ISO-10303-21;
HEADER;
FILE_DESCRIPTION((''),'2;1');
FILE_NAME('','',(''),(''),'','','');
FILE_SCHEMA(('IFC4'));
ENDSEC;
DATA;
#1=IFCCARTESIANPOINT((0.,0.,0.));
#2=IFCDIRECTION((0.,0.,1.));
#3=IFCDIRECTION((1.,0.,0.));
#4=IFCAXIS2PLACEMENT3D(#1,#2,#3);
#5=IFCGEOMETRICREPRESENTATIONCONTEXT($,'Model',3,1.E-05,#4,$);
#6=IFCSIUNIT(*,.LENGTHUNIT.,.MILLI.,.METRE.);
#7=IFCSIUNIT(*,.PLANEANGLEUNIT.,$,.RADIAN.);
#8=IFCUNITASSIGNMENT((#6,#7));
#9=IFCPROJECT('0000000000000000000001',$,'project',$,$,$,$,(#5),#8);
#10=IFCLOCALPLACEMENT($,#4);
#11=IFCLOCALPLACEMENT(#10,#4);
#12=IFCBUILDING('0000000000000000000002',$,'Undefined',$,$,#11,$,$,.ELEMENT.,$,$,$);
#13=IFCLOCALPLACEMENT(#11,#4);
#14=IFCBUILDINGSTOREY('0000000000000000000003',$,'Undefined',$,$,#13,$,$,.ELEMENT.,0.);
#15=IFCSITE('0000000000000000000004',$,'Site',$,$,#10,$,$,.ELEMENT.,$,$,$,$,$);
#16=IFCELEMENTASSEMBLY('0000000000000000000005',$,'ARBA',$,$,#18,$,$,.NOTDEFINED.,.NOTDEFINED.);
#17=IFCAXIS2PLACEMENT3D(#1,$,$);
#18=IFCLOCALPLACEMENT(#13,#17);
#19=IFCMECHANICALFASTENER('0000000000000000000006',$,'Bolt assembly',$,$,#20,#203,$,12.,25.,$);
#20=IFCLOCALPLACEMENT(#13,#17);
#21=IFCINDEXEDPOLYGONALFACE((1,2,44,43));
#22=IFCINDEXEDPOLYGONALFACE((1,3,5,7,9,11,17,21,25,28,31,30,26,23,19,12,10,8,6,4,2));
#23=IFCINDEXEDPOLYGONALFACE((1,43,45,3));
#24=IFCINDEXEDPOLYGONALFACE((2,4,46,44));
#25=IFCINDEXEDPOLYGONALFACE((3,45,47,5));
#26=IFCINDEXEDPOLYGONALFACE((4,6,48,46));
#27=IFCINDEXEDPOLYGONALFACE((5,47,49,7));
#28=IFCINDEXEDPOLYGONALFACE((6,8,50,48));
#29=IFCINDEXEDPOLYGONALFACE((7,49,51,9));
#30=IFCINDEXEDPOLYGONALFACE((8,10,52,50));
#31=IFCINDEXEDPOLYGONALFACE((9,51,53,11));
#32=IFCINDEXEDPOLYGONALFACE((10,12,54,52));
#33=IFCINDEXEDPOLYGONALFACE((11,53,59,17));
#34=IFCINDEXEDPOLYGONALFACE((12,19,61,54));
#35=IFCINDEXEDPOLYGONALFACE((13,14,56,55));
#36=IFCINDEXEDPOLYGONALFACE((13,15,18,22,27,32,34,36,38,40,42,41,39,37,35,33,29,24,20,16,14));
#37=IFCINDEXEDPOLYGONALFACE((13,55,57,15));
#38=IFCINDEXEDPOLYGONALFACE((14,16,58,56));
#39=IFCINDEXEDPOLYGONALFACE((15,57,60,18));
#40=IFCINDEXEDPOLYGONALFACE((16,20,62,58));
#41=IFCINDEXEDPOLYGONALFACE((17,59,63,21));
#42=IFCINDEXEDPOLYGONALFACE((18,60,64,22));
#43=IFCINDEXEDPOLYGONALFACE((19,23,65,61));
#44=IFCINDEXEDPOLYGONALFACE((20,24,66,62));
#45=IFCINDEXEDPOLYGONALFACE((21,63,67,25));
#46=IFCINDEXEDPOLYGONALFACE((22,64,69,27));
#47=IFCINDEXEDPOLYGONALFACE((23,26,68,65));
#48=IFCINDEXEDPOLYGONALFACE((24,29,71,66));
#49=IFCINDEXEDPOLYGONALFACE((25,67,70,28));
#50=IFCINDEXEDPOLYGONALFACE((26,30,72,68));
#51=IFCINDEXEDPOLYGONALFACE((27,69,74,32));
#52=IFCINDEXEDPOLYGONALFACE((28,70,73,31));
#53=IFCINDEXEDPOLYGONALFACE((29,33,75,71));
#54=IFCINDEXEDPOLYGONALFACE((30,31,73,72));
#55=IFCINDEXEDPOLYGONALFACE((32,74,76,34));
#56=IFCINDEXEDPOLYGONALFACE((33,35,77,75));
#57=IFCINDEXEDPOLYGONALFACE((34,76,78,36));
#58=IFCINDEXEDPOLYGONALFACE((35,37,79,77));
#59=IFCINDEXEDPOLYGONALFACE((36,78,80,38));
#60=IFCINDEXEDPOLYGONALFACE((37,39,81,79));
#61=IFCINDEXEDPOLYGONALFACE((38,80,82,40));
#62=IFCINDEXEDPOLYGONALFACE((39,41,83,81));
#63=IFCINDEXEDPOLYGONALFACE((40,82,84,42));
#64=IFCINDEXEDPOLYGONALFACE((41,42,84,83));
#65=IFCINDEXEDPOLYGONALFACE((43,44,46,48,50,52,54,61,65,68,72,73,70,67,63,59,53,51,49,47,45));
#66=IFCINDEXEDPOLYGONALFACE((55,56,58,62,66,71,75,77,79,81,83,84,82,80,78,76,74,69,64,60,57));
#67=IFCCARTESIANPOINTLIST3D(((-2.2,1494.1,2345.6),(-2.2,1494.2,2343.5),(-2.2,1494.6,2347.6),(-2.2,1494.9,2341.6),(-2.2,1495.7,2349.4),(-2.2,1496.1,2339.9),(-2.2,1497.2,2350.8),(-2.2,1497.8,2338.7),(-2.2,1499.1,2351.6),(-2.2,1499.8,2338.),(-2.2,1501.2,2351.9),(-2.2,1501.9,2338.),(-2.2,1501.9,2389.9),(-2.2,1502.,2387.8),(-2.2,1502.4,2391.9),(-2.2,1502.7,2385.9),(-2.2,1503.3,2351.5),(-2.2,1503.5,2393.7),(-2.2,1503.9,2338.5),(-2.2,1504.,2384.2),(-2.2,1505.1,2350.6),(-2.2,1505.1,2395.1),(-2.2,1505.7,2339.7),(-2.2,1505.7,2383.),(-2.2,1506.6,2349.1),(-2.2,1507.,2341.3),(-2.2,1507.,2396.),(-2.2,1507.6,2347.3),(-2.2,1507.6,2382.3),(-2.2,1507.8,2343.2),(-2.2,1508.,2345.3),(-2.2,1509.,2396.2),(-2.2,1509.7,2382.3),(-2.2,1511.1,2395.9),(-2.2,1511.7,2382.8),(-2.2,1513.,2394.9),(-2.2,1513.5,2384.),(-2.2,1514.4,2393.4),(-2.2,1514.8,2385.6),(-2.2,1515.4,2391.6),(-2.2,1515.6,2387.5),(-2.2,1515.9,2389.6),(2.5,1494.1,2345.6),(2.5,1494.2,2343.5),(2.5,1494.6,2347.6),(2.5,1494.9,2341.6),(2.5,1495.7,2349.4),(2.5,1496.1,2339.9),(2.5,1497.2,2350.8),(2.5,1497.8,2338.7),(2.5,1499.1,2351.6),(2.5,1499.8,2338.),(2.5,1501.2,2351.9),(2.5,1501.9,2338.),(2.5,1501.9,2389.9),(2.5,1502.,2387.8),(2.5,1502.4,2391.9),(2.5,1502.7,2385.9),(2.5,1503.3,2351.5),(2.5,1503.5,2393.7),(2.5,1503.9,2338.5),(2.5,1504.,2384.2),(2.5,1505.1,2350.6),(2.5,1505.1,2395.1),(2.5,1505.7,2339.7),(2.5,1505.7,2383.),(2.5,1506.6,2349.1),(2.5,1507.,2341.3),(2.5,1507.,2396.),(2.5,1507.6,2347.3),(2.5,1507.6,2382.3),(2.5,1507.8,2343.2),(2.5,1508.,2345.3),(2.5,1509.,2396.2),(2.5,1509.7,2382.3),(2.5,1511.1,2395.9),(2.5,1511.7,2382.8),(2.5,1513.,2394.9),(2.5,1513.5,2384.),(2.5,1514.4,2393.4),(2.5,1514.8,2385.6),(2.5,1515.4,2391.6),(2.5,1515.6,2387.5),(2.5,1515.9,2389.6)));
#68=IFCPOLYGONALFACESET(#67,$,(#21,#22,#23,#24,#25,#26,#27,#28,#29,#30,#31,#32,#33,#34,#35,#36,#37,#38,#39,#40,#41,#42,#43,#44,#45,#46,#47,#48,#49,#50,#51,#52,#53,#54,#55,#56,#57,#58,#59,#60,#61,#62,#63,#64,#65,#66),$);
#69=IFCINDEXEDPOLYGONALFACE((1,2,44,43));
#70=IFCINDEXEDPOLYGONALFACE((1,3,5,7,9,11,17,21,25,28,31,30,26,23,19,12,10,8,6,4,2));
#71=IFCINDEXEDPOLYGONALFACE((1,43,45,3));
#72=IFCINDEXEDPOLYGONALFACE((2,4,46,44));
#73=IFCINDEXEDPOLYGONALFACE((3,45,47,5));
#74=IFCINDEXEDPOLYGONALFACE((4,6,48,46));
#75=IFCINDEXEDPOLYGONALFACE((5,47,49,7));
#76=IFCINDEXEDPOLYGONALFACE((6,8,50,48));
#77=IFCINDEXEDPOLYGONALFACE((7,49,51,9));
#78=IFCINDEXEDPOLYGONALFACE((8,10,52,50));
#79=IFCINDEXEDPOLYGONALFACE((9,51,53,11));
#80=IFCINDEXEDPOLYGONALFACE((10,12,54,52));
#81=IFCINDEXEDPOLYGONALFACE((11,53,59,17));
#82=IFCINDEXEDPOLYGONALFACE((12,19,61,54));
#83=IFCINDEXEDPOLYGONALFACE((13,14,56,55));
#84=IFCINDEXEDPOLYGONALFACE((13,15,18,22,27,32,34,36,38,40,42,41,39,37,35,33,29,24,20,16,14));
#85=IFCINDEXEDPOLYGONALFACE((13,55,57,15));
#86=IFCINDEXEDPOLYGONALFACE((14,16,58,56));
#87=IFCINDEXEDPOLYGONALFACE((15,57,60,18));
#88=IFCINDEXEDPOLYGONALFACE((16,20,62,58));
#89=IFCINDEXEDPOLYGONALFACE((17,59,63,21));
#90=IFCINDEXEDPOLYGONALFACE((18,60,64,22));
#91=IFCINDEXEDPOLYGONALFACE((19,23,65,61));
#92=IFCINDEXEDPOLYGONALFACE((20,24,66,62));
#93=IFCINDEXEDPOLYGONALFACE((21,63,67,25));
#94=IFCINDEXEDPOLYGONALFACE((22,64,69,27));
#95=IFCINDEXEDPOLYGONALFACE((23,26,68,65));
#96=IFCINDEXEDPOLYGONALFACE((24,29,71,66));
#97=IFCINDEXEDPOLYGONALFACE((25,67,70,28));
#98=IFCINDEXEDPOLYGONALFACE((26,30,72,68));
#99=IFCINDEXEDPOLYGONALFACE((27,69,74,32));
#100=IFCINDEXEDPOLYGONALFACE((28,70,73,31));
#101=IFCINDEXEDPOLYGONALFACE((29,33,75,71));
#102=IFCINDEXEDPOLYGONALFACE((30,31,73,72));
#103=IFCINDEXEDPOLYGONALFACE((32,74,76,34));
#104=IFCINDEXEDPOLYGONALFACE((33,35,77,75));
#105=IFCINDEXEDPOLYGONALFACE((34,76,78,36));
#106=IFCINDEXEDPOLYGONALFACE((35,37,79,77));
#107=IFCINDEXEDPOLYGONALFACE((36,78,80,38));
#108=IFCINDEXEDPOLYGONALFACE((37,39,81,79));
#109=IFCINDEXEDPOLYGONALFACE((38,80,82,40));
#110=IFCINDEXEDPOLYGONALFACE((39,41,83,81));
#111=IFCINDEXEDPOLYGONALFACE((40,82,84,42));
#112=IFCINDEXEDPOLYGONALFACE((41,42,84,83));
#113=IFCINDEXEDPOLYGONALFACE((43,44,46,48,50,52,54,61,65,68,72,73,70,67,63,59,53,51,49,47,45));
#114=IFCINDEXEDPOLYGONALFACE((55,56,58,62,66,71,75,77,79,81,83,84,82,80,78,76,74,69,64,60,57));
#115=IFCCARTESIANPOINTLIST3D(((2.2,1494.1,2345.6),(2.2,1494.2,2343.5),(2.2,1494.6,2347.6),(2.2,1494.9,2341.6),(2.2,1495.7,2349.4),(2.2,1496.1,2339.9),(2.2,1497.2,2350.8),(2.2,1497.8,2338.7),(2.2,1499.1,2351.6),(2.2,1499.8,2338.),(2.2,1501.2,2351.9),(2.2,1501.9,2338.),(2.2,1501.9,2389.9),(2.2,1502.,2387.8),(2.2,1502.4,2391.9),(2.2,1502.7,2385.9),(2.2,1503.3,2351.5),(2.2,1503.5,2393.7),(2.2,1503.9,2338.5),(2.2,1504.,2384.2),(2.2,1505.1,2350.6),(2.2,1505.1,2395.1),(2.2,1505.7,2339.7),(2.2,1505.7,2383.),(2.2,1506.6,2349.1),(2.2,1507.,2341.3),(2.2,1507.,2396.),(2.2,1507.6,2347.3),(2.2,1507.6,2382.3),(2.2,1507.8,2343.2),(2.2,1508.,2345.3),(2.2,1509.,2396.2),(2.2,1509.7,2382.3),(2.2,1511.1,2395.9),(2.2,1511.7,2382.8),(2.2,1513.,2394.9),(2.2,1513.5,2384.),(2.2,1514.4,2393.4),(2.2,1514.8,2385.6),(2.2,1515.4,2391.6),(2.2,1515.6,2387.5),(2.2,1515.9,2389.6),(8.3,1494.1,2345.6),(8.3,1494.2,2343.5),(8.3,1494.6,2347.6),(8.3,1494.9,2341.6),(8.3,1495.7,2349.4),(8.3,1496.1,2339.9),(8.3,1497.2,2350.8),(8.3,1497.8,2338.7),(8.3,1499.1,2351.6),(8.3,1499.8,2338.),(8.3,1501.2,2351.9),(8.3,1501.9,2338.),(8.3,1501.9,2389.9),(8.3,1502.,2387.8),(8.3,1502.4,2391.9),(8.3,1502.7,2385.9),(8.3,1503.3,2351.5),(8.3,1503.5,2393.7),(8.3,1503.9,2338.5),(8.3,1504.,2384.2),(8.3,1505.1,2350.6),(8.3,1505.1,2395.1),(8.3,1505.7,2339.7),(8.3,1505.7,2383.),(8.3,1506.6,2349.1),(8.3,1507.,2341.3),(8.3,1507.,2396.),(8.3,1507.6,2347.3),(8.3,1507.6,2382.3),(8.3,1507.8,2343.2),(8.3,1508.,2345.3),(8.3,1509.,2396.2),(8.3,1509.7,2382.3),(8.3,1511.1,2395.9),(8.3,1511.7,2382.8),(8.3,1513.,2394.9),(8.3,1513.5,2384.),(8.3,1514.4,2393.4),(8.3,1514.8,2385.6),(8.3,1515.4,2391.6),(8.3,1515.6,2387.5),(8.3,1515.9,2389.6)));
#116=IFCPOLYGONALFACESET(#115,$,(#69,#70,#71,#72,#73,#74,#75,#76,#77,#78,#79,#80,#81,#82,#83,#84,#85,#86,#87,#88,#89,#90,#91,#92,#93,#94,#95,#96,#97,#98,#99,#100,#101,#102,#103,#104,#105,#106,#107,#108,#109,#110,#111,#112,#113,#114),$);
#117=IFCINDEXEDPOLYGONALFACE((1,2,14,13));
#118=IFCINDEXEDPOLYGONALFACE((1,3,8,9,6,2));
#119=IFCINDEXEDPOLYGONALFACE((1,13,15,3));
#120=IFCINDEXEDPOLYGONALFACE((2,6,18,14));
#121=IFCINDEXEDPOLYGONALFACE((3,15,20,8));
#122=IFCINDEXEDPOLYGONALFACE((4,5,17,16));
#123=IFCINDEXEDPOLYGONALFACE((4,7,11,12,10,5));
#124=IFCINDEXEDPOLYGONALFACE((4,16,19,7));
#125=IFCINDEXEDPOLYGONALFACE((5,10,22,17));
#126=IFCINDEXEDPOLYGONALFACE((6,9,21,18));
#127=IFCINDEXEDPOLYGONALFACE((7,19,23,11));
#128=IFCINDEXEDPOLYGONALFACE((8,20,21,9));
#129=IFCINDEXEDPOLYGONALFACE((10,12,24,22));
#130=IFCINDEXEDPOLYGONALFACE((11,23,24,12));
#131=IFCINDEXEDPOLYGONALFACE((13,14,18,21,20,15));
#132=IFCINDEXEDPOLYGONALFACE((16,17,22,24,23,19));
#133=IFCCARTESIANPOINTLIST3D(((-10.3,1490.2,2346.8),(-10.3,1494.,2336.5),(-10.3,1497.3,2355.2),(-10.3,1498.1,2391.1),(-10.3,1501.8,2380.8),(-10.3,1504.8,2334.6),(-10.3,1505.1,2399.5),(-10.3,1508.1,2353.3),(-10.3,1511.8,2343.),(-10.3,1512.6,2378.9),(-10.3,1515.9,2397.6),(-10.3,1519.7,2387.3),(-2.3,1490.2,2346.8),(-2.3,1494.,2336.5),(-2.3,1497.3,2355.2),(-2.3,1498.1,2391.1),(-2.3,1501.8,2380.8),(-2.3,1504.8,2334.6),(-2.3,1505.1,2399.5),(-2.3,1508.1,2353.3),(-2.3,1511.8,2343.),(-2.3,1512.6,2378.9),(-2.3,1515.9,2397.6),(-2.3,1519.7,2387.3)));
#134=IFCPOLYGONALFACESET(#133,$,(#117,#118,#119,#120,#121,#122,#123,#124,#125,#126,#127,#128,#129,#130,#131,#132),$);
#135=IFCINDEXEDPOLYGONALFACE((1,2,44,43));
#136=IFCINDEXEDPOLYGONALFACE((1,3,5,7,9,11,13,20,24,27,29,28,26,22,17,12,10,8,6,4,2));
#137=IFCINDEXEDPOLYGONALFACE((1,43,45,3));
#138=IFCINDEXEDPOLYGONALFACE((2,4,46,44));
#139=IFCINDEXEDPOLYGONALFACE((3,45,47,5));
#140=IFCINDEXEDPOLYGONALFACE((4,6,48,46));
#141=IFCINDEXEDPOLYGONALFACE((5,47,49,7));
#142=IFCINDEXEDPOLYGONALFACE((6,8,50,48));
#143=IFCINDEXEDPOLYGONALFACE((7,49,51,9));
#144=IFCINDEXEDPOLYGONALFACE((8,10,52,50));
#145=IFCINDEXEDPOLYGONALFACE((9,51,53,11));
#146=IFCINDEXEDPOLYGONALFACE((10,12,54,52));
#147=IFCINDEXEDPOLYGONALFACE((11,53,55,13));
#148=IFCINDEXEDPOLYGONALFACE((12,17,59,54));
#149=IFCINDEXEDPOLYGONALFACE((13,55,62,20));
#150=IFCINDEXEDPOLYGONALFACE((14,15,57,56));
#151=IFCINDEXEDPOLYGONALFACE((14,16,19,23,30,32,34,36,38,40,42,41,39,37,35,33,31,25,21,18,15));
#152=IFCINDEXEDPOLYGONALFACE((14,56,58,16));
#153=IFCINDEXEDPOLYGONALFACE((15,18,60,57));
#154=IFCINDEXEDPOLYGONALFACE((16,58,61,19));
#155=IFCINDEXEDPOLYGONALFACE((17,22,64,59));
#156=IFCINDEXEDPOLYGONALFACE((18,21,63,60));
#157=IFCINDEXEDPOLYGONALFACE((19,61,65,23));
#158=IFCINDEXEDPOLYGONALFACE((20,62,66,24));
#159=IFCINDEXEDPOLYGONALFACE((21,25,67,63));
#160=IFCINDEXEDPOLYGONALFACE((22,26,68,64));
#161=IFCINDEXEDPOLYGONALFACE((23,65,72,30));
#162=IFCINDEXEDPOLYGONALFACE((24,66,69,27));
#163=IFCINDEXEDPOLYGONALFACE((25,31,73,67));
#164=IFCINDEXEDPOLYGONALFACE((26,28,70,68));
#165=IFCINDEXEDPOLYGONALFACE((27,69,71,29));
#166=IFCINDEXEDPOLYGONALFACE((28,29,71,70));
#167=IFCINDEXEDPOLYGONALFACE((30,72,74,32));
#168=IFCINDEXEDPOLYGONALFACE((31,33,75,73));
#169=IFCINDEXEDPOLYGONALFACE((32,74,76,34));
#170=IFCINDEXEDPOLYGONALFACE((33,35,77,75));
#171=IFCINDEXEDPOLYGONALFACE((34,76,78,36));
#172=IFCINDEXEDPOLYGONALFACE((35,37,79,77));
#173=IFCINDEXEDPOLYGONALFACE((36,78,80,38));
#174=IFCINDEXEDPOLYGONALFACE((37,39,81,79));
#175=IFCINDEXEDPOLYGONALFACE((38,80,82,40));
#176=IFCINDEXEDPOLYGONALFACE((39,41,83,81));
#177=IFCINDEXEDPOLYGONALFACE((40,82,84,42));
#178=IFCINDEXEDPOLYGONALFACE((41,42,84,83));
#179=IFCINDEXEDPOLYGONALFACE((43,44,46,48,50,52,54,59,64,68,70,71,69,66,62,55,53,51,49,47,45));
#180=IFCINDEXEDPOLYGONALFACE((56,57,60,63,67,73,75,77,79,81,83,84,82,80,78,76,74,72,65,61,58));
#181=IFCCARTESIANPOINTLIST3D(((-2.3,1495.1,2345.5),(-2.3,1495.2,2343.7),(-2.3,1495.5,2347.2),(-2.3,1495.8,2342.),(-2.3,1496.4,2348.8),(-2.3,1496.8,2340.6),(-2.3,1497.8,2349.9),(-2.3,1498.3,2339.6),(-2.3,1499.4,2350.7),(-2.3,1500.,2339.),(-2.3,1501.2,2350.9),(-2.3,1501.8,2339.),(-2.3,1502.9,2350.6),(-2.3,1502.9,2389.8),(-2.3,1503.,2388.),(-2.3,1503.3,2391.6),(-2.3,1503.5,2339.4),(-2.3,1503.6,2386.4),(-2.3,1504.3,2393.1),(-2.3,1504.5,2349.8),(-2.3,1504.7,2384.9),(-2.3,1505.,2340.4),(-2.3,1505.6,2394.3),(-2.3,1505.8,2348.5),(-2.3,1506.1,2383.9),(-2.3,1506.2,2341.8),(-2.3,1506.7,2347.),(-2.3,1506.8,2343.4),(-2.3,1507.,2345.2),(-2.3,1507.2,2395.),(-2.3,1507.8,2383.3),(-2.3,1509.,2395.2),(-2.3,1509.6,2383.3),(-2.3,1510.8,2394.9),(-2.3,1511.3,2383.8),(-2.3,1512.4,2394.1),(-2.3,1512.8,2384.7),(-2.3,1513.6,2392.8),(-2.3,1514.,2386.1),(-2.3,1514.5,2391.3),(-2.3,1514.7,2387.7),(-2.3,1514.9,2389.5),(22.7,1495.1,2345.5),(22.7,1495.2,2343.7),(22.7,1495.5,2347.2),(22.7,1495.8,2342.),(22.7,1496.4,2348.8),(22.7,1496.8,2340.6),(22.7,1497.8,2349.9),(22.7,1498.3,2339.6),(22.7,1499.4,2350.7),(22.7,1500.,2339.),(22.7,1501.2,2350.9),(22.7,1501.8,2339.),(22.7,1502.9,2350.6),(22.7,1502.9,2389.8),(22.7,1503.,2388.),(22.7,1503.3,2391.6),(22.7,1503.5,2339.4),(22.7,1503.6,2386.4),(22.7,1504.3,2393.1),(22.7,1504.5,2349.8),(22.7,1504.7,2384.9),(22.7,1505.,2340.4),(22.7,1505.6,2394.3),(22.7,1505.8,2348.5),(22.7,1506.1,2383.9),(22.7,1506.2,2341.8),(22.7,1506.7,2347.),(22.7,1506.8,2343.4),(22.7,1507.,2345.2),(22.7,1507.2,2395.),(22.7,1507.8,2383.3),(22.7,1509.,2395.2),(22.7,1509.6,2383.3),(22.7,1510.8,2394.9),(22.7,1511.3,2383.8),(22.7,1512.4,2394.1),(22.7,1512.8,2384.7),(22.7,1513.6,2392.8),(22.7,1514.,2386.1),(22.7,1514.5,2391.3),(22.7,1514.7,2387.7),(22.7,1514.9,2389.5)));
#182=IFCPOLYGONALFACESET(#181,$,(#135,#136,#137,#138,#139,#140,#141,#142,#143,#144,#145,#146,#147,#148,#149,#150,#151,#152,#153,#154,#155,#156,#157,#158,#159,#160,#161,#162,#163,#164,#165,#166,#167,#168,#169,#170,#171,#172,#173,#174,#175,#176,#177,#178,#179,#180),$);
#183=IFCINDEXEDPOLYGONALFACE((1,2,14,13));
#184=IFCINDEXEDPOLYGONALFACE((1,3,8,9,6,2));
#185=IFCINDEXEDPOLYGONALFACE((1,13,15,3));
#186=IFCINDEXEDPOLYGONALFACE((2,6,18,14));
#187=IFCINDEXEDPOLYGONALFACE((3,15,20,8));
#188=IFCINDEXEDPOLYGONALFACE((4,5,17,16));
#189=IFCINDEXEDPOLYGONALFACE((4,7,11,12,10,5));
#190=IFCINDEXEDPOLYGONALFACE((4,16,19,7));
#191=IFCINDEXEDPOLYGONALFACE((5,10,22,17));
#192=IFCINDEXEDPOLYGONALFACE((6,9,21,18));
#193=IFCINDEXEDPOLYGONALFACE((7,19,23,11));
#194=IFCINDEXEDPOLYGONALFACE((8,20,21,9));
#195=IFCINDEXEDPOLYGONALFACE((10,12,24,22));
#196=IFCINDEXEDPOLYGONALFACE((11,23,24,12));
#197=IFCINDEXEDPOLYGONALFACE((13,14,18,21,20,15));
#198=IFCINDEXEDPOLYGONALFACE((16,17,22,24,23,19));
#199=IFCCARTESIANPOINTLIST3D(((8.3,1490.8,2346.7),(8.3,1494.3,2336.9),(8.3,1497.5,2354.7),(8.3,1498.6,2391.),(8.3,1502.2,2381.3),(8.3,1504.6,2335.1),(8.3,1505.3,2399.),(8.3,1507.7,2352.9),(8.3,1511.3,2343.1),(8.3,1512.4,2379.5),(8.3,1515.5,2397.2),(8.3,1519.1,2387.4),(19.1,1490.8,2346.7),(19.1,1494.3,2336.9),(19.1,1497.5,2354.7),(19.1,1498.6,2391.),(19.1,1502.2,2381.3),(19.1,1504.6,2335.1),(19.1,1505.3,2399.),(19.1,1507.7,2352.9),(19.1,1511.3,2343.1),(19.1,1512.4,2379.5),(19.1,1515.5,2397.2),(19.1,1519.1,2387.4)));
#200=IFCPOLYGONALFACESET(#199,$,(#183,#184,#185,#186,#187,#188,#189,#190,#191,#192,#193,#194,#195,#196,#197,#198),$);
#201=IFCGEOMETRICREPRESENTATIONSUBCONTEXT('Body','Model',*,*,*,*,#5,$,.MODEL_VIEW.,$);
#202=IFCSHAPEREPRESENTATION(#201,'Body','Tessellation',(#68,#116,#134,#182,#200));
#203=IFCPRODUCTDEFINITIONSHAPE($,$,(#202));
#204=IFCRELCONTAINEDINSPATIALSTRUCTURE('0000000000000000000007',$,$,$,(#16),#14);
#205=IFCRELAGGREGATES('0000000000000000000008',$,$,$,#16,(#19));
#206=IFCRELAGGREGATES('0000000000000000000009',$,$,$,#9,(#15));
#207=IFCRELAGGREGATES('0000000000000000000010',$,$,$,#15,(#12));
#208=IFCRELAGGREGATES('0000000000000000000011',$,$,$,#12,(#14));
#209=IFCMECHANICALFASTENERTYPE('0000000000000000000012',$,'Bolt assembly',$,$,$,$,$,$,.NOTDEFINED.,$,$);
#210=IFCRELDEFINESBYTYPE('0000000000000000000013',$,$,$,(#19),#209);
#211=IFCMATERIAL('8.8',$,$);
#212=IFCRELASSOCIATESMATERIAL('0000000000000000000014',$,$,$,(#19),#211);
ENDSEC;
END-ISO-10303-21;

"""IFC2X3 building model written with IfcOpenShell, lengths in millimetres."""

from ifc_helpers import new_model, si_unit, frame, origin_with_axes, origin_2d_with_axis, place, context, subcontext, project, spatial, polyline, circle, outline, extrude, source, transform, mapped, material, type_object, element, aggregate, save


model = new_model("IFC2X3")

# Units and contexts
model_context = context("Model", 3, precision=1e-05, world=origin_with_axes())
body_context = subcontext(model_context, "Body", "Model", "MODEL_VIEW")
ifc_project = project(units=[si_unit("LENGTHUNIT", "METRE", prefix="MILLI"), si_unit("PLANEANGLEUNIT", "RADIAN")], contexts=[model_context])

# Site, building, storey
site_placement = place(None, origin_with_axes())
site = spatial("IfcSite", under=ifc_project, at=site_placement, Name="Site", CompositionType="ELEMENT")
building_placement = place(site_placement, origin_with_axes())
building = spatial("IfcBuilding", under=site, at=building_placement, Name="Undefined", CompositionType="ELEMENT")
storey_placement = place(building_placement, origin_with_axes())
storey = spatial("IfcBuildingStorey", under=building, at=storey_placement, Name="Undefined", CompositionType="ELEMENT", Elevation=0.0)

# Shared definitions
ifc_material_1 = material(Name="8.8")
mechanical_fastener_type = type_object("IfcMechanicalFastenerType", Name="Bolt assembly")

# Element assembly, mechanical fastener
assembly_1_placement = place(storey_placement, origin_with_axes())
assembly_1 = element("IfcElementAssembly", 1, at=assembly_1_placement, inside=storey, Name="ARBA", AssemblyPlace="NOTDEFINED", PredefinedType="NOTDEFINED")
shared_shape_1 = source(origin_with_axes(), body_context, "Body", "SweptSolid", [
    extrude(circle(Radius=7.0, at=origin_2d_with_axis()), frame((0.0, -10.6, 0.0), z_axis=(0.0, 1.0, 0.0), x_axis=(1.0, 0.0, 0.0)), (0.0, 0.0, 1.0), 4.7),
    extrude(circle(Radius=7.0, at=origin_2d_with_axis()), frame((0.0, -6.1, 0.0), z_axis=(0.0, 1.0, 0.0), x_axis=(1.0, 0.0, 0.0)), (0.0, 0.0, 1.0), 6.1),
    extrude(outline(polyline([(9.5, -5.5), (9.5, 5.5), (0.0, 11.0), (-9.5, 5.5), (-9.5, -5.5), (0.0, -11.0), (9.5, -5.5)])), frame((0.0, -18.7, 0.0), z_axis=(0.0, 1.0, 0.0), x_axis=(1.0, 0.0, 0.0)), (0.0, 0.0, 1.0), 8.0),
    extrude(circle(Radius=6.0, at=origin_2d_with_axis()), frame((0.0, -10.7, 0.0), z_axis=(0.0, 1.0, 0.0), x_axis=(1.0, 0.0, 0.0)), (0.0, 0.0, 1.0), 25.0),
    extrude(outline(polyline([(9.0, -5.2), (9.0, 5.2), (0.0, 10.4), (-9.0, 5.2), (-9.0, -5.2), (0.0, -10.4), (9.0, -5.2)])), frame((0.0, 0.0, 0.0), z_axis=(0.0, 1.0, 0.0), x_axis=(1.0, 0.0, 0.0)), (0.0, 0.0, 1.0), 10.8),
])
mechanical_fastener_1_placement = place(assembly_1_placement, frame((8.3, 1508.9, 2389.2), z_axis=(0.0, -0.984742, 0.174019), x_axis=(0.0, -0.174019, -0.984742)))
mechanical_fastener_1 = element("IfcMechanicalFastener", 2, at=mechanical_fastener_1_placement, type_object=mechanical_fastener_type, material=ifc_material_1, Name="Bolt assembly", NominalDiameter=12.0, NominalLength=25.0, context=body_context, shape_type="MappedRepresentation", body=[
    mapped(shared_shape_1, transform((0.0, 0.0, 0.0))),
    mapped(shared_shape_1, transform((45.0, 0.0, 0.0))),
])
aggregate(assembly_1, [mechanical_fastener_1])

save(model, "model.ifc")
